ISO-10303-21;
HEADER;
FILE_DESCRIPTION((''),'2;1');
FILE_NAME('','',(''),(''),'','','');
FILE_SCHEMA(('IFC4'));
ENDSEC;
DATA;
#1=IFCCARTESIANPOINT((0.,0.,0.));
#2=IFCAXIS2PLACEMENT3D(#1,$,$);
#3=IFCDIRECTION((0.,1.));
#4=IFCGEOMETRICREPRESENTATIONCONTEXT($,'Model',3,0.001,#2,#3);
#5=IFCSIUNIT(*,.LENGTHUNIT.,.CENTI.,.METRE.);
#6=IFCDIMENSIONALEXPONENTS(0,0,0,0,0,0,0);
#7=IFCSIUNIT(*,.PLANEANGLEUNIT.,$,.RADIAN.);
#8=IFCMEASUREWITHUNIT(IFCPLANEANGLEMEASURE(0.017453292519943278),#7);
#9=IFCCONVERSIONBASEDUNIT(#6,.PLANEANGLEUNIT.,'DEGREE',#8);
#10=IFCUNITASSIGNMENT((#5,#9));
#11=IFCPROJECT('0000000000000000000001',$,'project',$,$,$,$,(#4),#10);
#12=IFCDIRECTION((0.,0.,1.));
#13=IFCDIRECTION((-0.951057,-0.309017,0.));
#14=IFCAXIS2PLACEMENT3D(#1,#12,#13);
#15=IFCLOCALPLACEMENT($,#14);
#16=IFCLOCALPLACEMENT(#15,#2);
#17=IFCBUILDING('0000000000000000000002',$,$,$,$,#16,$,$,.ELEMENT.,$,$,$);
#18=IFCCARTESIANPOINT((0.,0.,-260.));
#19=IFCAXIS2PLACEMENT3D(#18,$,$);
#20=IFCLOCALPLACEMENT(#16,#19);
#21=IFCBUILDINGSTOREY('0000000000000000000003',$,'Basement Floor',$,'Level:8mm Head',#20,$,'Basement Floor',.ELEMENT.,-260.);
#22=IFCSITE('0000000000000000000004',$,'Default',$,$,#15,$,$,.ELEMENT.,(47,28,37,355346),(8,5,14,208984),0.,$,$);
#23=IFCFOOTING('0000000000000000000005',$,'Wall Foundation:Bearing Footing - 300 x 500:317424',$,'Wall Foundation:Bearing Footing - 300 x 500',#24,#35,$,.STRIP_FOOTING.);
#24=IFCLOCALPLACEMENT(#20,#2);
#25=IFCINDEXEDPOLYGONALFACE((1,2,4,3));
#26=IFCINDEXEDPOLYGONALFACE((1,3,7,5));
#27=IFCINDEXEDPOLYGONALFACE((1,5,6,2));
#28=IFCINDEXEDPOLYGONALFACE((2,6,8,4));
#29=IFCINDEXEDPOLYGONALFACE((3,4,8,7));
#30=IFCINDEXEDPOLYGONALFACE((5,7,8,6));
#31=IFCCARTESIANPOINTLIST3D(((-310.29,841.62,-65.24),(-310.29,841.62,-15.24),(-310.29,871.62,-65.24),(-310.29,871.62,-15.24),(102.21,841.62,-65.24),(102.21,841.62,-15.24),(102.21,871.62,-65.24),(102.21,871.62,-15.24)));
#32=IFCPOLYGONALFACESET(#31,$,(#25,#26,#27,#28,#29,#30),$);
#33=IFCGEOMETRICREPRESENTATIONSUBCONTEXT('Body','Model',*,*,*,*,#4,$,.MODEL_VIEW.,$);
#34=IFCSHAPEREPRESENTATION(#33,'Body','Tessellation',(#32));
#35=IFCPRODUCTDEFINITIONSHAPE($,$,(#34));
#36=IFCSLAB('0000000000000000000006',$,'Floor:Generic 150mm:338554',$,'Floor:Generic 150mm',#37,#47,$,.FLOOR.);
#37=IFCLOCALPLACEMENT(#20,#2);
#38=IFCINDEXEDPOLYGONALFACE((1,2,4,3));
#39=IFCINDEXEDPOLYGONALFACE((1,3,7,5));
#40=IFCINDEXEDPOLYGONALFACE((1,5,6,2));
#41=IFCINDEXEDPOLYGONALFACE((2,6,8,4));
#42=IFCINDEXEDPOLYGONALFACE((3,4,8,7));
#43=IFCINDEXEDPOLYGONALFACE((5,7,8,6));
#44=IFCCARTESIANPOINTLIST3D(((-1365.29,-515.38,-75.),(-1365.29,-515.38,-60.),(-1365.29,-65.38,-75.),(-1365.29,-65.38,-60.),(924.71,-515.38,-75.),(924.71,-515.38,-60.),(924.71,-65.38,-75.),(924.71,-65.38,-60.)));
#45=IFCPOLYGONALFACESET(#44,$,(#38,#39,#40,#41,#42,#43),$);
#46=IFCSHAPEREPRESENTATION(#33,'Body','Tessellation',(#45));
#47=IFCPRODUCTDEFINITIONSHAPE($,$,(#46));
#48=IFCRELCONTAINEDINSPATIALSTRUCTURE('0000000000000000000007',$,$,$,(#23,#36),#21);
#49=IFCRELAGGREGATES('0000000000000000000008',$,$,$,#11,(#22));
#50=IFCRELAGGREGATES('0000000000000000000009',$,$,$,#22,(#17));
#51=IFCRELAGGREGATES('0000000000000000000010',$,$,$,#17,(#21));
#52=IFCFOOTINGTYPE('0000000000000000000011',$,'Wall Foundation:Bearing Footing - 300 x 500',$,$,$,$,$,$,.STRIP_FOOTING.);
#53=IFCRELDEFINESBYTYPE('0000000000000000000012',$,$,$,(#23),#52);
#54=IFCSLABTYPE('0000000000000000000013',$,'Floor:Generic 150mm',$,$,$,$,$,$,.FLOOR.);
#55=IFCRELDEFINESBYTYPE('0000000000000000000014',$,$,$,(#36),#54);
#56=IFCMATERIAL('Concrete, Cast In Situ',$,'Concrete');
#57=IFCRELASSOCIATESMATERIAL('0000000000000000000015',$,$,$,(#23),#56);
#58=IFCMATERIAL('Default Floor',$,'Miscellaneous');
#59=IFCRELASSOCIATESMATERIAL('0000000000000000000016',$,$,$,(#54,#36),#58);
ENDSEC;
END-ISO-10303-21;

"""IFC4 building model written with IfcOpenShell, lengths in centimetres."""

from ifc_helpers import new_model, entity, si_unit, converted_unit, direction, frame, origin, place, context, subcontext, project, spatial, indexed_curve, outline, extrude, material, type_object, element, save


model = new_model("IFC4")

# Units and contexts
model_context = context("Model", 3, precision=0.001, world=origin(), true_north=direction((0.0, 1.0)))
body_context = subcontext(model_context, "Body", "Model", "MODEL_VIEW")
ifc_project = project(units=[si_unit("LENGTHUNIT", "METRE", prefix="CENTI"), converted_unit("PLANEANGLEUNIT", "DEGREE", entity("IfcPlaneAngleMeasure", 0.017453292519943278), si_unit("PLANEANGLEUNIT", "RADIAN"), dimensions=[0, 0, 0, 0, 0, 0, 0])], contexts=[model_context])

# Site, building, storey
site_placement = place(None, frame((0.0, 0.0, 0.0), z_axis=(0.0, 0.0, 1.0), x_axis=(-0.951057, -0.309017, 0.0)))
site = spatial("IfcSite", under=ifc_project, at=site_placement, Name="Default", CompositionType="ELEMENT", RefLatitude=(47, 28, 37, 355346), RefLongitude=(8, 5, 14, 208984), RefElevation=0.0)
building_placement = place(site_placement, origin())
building = spatial("IfcBuilding", under=site, at=building_placement, CompositionType="ELEMENT")
storey_placement = place(building_placement, frame((0.0, 0.0, -260.0)))
storey = spatial("IfcBuildingStorey", under=building, at=storey_placement, Name="Basement Floor", ObjectType="Level:8mm Head", LongName="Basement Floor", CompositionType="ELEMENT", Elevation=-260.0)

# Footing
ifc_material_1 = material(Name="Concrete, Cast In Situ", Category="Concrete")
footing_type = type_object("IfcFootingType", Name="Wall Foundation:Bearing Footing - 300 x 500", PredefinedType="STRIP_FOOTING")
footing_1_placement = place(storey_placement, origin())
element("IfcFooting", 1, at=footing_1_placement, inside=storey, type_object=footing_type, material=ifc_material_1, Name="Wall Foundation:Bearing Footing - 300 x 500:317424", ObjectType="Wall Foundation:Bearing Footing - 300 x 500", PredefinedType="STRIP_FOOTING", context=body_context, shape_type="SweptSolid", body=[
    extrude(outline(indexed_curve([(-206.25, -15.0), (206.25, -15.0), (206.25, 15.0), (-206.25, 15.0), (-206.25, -15.0)], self_intersect=False)), frame((-104.04, 856.62, -65.24), z_axis=(0.0, 0.0, 1.0), x_axis=(-1.0, 0.0, 0.0)), (0.0, 0.0, 1.0), 50.0),
])

# Slab
ifc_material_2 = material(Name="Default Floor", Category="Miscellaneous")
slab_type = type_object("IfcSlabType", Name="Floor:Generic 150mm", PredefinedType="FLOOR", material=ifc_material_2)
slab_placement = place(storey_placement, origin())
element("IfcSlab", 2, at=slab_placement, inside=storey, type_object=slab_type, material=ifc_material_2, Name="Floor:Generic 150mm:338554", ObjectType="Floor:Generic 150mm", PredefinedType="FLOOR", context=body_context, shape_type="SweptSolid", body=[
    extrude(outline(indexed_curve([(-225.0, -1145.0), (225.0, -1145.0), (225.0, 1145.0), (-225.0, 1145.0), (-225.0, -1145.0)], self_intersect=False)), frame((-220.29, -290.38, -60.0), z_axis=(0.0, 0.0, -1.0), x_axis=(0.0, 1.0, 0.0)), (0.0, 0.0, 1.0), 15.0),
])

save(model, "model.ifc")
